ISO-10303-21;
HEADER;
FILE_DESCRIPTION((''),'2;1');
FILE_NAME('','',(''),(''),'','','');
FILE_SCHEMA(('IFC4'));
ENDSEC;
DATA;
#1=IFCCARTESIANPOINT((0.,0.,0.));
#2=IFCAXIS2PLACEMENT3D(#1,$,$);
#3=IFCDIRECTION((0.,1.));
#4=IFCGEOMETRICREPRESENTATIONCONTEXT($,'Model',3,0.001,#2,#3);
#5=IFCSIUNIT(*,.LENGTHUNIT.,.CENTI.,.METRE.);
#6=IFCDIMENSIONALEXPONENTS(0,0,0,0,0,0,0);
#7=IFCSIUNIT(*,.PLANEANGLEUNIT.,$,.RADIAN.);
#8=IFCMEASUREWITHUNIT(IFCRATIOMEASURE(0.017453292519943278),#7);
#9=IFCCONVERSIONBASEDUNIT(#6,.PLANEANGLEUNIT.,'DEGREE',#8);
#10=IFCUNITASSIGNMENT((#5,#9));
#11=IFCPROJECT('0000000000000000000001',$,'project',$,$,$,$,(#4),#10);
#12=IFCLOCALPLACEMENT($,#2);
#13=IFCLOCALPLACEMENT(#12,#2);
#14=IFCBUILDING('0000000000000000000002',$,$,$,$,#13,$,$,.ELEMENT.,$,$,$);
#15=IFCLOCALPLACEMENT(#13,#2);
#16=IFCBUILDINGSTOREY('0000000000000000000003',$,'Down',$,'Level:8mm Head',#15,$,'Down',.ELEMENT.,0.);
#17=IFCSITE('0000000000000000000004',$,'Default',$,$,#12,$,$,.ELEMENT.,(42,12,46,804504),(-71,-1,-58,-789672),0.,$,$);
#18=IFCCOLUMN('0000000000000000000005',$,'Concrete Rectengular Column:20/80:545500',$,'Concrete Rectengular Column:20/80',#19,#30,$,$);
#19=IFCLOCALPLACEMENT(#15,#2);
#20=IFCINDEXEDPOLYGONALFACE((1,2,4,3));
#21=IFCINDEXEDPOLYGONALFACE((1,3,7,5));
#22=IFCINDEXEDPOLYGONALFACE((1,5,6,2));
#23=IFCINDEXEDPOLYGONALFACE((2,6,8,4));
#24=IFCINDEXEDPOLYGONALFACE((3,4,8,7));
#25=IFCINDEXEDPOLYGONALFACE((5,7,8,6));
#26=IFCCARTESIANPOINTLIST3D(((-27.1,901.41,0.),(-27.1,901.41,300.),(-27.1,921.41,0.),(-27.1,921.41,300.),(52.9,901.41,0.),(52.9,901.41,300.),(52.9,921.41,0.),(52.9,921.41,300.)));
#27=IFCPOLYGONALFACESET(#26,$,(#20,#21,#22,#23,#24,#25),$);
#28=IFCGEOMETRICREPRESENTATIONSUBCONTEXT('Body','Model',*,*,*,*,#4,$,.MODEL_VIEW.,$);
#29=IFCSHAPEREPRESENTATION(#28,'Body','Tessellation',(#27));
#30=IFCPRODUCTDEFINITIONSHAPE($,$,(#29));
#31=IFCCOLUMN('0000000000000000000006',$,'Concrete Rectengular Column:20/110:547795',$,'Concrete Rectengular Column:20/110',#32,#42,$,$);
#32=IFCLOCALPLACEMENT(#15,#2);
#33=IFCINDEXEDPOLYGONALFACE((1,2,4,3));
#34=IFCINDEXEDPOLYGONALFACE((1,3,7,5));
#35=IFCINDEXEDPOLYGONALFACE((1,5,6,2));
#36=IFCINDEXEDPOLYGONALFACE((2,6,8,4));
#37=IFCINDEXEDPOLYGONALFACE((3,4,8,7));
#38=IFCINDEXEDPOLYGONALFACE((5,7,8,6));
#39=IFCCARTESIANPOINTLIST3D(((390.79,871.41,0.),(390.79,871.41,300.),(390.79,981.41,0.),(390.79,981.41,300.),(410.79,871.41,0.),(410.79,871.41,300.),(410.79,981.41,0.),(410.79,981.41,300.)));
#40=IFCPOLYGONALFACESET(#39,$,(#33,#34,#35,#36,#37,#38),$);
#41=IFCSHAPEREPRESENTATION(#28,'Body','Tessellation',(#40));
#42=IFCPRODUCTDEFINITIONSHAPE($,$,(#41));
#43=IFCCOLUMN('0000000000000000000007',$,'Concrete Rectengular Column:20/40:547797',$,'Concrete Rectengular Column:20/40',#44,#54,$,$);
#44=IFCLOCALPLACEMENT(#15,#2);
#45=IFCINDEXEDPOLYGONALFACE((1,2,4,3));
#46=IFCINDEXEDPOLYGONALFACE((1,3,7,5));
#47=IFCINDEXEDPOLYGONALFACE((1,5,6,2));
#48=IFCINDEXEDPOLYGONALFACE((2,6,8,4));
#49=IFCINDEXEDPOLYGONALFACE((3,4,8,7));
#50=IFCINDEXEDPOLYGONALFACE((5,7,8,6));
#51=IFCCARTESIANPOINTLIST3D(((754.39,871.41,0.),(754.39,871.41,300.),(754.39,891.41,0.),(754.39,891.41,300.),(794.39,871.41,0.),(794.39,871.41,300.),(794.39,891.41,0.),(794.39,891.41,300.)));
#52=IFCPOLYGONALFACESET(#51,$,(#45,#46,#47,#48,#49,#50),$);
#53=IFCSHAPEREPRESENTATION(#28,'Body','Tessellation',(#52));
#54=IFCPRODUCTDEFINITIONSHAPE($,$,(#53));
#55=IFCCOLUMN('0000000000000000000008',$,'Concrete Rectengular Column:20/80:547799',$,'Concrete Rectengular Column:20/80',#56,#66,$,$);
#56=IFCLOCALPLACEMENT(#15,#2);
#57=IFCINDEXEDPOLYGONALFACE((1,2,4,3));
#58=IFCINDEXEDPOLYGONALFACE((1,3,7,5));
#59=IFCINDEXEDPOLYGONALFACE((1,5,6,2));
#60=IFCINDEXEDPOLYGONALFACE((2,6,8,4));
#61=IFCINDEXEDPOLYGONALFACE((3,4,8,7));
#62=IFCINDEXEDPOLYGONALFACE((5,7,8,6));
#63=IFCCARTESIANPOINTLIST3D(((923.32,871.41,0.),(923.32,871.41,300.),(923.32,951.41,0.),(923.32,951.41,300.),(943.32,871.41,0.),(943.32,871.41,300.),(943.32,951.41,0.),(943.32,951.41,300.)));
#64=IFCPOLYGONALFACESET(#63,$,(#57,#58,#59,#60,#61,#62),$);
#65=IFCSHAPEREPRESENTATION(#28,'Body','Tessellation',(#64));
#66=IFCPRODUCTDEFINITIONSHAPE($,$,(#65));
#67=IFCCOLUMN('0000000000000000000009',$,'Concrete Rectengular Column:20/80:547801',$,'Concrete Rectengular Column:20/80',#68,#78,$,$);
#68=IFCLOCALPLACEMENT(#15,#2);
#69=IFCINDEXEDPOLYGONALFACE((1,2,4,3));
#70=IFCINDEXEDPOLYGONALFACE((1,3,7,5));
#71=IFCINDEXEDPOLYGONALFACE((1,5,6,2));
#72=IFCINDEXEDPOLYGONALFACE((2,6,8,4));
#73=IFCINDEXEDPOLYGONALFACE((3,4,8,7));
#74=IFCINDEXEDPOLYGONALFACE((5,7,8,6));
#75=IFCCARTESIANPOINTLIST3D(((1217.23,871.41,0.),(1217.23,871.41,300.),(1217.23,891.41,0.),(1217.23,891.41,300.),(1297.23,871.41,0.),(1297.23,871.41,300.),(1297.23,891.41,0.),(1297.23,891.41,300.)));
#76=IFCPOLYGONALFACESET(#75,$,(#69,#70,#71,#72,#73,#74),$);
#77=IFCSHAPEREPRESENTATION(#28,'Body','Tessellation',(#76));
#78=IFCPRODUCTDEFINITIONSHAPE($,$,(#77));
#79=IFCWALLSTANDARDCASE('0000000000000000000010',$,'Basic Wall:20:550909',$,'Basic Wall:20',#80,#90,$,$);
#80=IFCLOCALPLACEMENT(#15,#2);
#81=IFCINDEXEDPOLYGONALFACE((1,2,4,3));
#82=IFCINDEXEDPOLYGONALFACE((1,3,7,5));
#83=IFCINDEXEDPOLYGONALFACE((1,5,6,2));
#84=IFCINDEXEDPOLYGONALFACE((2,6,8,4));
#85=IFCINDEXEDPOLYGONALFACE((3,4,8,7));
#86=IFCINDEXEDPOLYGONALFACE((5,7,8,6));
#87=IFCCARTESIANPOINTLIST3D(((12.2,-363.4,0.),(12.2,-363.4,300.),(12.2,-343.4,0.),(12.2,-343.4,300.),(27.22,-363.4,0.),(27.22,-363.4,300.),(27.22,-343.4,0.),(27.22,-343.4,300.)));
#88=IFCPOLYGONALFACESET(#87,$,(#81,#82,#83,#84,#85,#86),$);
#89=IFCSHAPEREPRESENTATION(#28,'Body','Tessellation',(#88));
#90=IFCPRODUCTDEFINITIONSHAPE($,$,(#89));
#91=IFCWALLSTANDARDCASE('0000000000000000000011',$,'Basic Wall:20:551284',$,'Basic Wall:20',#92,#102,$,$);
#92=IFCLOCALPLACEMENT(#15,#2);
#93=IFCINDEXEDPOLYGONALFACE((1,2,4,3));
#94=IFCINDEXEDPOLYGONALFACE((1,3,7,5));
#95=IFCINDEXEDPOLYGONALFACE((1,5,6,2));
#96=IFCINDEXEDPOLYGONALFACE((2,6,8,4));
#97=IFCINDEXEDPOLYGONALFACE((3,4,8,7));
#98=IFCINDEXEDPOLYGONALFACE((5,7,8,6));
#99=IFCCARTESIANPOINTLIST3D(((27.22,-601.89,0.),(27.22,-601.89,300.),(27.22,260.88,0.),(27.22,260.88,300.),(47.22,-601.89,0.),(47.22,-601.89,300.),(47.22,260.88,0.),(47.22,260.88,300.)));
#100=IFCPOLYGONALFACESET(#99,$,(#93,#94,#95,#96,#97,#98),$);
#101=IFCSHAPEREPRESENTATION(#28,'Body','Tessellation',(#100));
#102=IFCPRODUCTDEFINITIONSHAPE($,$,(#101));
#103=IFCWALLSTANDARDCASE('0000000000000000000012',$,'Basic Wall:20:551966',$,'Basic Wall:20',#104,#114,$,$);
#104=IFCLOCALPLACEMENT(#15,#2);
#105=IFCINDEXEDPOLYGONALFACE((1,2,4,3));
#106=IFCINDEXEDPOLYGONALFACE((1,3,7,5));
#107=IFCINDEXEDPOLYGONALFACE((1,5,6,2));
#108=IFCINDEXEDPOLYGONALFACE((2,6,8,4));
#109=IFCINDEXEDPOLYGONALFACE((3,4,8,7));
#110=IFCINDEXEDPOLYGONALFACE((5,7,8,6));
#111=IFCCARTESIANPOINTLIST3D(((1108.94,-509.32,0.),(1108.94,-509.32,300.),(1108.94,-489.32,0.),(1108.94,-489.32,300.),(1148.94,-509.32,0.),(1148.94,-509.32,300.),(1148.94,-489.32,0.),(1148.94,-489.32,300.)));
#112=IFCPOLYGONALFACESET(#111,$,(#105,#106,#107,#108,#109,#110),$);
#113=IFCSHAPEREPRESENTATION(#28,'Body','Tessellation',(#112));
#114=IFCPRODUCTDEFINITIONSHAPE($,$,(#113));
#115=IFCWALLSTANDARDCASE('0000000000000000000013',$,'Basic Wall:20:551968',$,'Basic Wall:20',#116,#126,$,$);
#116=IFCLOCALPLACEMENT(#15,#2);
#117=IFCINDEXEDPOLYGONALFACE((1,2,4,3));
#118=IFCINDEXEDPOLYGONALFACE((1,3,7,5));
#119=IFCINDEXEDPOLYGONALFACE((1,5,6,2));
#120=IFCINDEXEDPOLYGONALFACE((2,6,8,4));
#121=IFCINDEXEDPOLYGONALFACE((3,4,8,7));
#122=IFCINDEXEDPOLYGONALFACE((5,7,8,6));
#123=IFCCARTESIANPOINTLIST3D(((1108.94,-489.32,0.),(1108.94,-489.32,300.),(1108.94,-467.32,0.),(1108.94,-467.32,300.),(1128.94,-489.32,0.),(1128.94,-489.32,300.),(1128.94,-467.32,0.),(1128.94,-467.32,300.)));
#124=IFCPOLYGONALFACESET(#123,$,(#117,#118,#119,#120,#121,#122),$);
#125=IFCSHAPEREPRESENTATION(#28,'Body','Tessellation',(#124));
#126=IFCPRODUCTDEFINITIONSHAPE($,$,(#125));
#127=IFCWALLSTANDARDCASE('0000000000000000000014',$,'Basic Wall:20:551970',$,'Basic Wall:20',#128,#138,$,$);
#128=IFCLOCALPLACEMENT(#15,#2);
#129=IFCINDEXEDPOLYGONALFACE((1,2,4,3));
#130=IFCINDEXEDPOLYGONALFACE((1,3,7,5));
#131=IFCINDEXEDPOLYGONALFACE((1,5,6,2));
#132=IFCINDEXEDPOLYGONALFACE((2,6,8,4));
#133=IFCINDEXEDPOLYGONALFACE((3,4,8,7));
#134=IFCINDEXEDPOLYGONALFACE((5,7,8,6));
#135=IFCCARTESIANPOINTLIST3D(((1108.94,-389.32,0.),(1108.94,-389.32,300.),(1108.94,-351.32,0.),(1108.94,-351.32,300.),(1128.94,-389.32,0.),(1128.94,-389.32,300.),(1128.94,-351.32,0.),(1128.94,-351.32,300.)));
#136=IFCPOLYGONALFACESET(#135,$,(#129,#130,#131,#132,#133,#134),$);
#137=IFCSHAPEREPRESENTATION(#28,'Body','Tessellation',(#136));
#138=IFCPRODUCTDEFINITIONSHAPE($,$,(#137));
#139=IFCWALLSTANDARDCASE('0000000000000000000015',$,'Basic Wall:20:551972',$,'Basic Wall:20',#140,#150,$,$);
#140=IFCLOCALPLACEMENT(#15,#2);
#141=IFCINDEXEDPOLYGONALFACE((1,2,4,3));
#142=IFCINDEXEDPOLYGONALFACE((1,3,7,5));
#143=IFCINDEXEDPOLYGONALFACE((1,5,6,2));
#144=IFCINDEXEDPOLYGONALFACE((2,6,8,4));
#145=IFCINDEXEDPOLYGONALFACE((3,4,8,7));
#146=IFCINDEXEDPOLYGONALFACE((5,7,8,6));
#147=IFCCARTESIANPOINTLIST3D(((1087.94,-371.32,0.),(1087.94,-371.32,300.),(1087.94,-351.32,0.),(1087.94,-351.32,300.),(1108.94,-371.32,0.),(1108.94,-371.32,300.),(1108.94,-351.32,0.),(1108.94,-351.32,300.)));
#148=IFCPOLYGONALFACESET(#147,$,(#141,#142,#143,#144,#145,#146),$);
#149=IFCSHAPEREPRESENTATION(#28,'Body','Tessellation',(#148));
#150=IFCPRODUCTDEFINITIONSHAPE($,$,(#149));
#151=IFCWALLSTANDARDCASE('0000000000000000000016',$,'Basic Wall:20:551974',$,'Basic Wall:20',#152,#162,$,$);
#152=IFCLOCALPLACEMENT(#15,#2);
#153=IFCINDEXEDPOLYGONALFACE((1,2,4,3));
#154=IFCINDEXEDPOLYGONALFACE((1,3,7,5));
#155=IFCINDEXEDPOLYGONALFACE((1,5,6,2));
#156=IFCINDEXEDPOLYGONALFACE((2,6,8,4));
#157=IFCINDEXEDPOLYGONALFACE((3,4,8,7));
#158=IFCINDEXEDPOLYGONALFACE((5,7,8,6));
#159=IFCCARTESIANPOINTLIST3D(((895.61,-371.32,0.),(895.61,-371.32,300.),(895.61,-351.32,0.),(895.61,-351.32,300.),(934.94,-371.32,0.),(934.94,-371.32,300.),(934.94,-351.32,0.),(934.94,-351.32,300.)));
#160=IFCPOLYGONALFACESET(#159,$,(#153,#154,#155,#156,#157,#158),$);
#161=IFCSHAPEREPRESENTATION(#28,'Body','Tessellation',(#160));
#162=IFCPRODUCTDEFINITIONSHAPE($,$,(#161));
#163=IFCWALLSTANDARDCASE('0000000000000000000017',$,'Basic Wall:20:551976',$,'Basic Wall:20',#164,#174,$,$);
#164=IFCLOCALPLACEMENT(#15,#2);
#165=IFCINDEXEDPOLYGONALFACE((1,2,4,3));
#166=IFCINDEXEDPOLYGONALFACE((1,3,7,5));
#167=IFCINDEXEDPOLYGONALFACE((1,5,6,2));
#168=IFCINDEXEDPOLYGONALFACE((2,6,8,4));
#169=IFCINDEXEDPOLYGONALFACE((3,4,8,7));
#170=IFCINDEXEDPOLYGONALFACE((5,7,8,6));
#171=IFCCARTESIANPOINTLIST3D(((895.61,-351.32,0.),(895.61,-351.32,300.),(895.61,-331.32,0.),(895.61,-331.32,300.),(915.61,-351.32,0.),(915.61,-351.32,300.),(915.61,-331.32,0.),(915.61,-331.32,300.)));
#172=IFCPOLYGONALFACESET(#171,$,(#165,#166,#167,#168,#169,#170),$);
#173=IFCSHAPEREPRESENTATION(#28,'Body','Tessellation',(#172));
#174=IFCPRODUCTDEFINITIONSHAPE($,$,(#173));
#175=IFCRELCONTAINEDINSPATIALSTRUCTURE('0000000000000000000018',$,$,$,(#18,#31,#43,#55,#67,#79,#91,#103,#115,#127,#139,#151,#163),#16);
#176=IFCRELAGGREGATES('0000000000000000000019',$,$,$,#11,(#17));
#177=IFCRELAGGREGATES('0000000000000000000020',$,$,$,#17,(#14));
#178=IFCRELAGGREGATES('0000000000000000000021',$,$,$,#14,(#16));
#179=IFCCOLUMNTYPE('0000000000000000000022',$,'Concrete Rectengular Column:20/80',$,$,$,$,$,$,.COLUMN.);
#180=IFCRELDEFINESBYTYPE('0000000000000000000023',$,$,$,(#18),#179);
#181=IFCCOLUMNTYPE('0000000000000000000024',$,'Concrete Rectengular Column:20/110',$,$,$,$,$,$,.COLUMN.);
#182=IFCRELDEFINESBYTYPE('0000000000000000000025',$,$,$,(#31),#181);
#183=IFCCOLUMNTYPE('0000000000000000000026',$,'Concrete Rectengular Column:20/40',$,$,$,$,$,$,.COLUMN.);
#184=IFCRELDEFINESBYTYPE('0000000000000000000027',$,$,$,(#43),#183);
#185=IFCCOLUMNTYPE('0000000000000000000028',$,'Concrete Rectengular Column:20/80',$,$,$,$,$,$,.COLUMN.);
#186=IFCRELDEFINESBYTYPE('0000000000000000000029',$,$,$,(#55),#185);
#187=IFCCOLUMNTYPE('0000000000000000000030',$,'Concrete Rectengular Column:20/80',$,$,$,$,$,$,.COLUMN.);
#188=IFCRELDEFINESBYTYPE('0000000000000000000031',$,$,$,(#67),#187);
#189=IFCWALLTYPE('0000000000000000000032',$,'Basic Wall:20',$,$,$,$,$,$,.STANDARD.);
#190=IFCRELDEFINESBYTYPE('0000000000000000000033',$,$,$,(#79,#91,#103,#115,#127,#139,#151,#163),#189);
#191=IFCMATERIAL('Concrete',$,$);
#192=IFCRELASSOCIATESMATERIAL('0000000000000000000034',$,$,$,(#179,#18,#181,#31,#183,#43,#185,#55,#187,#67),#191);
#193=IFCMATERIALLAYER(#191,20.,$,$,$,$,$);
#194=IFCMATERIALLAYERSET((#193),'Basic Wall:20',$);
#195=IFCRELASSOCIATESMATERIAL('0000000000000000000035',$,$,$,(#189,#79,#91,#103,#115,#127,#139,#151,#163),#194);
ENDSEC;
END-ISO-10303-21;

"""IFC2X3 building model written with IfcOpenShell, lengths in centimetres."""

from ifc_helpers import new_model, entity, si_unit, converted_unit, direction, frame, frame_2d, origin, origin_2d_with_axis, place, context, subcontext, project, spatial, rectangle, extrude, source, transform, mapped, material, layer, layer_set, layer_usage, type_object, type_shapes, element, save


model = new_model("IFC2X3")

# Units and contexts
model_context = context("Model", 3, precision=0.001, world=origin(), true_north=direction((0.0, 1.0)))
body_context = subcontext(model_context, "Body", "Model", "MODEL_VIEW")
ifc_project = project(units=[si_unit("LENGTHUNIT", "METRE", prefix="CENTI"), converted_unit("PLANEANGLEUNIT", "DEGREE", entity("IfcRatioMeasure", 0.017453292519943278), si_unit("PLANEANGLEUNIT", "RADIAN"), dimensions=[0, 0, 0, 0, 0, 0, 0])], contexts=[model_context])

# Site, building, storey
site_placement = place(None, origin())
site = spatial("IfcSite", under=ifc_project, at=site_placement, Name="Default", CompositionType="ELEMENT", RefLatitude=(42, 12, 46, 804504), RefLongitude=(-71, -1, -58, -789672), RefElevation=0.0)
building_placement = place(site_placement, origin())
building = spatial("IfcBuilding", under=site, at=building_placement, CompositionType="ELEMENT")
storey_placement = place(building_placement, origin())
storey = spatial("IfcBuildingStorey", under=building, at=storey_placement, Name="Down", ObjectType="Level:8mm Head", LongName="Down", CompositionType="ELEMENT", Elevation=0.0)

# Columns
ifc_material = material(Name="Concrete")
column_type_1 = type_object("IfcColumnType", Name="Concrete Rectengular Column:20/80", PredefinedType="COLUMN", material=ifc_material)
shared_shape_1 = source(origin(), body_context, "Body", "SweptSolid", [
    extrude(rectangle(XDim=20.0, YDim=80.0, at=origin_2d_with_axis()), frame((12.9, 911.41, 0.0), z_axis=(0.0, 0.0, 1.0), x_axis=(0.0, -1.0, 0.0)), (0.0, 0.0, 1.0), 300.0),
])
type_shapes(column_type_1, [shared_shape_1])
column_1_placement = place(storey_placement, origin())
element("IfcColumn", 1, at=column_1_placement, inside=storey, type_object=column_type_1, material=ifc_material, Name="Concrete Rectengular Column:20/80:545500", ObjectType="Concrete Rectengular Column:20/80", context=body_context, shape_type="MappedRepresentation", body=[
    mapped(shared_shape_1, transform((0.0, 0.0, 0.0), scale=1.0)),
])
column_type_2 = type_object("IfcColumnType", Name="Concrete Rectengular Column:20/110", PredefinedType="COLUMN", material=ifc_material)
shared_shape_2 = source(origin(), body_context, "Body", "SweptSolid", [
    extrude(rectangle(XDim=110.0, YDim=20.0, at=frame_2d((0.0, 0.0), x_axis=(1.0, 0.0))), frame((400.79, 926.41, 0.0), z_axis=(0.0, 0.0, 1.0), x_axis=(0.0, -1.0, 0.0)), (0.0, 0.0, 1.0), 300.0),
])
type_shapes(column_type_2, [shared_shape_2])
column_2_placement = place(storey_placement, origin())
element("IfcColumn", 2, at=column_2_placement, inside=storey, type_object=column_type_2, material=ifc_material, Name="Concrete Rectengular Column:20/110:547795", ObjectType="Concrete Rectengular Column:20/110", context=body_context, shape_type="MappedRepresentation", body=[
    mapped(shared_shape_2, transform((0.0, 0.0, 0.0), scale=1.0)),
])
column_type_3 = type_object("IfcColumnType", Name="Concrete Rectengular Column:20/40", PredefinedType="COLUMN", material=ifc_material)
shared_shape_3 = source(origin(), body_context, "Body", "SweptSolid", [
    extrude(rectangle(XDim=20.0, YDim=40.0, at=origin_2d_with_axis()), frame((774.39, 881.41, 0.0), z_axis=(0.0, 0.0, 1.0), x_axis=(0.0, -1.0, 0.0)), (0.0, 0.0, 1.0), 300.0),
])
type_shapes(column_type_3, [shared_shape_3])
column_3_placement = place(storey_placement, origin())
element("IfcColumn", 3, at=column_3_placement, inside=storey, type_object=column_type_3, material=ifc_material, Name="Concrete Rectengular Column:20/40:547797", ObjectType="Concrete Rectengular Column:20/40", context=body_context, shape_type="MappedRepresentation", body=[
    mapped(shared_shape_3, transform((0.0, 0.0, 0.0), scale=1.0)),
])
column_type_4 = type_object("IfcColumnType", Name="Concrete Rectengular Column:20/80", PredefinedType="COLUMN", material=ifc_material)
shared_shape_4 = source(origin(), body_context, "Body", "SweptSolid", [
    extrude(rectangle(XDim=80.0, YDim=20.0, at=origin_2d_with_axis()), frame((933.32, 911.41, 0.0), z_axis=(0.0, 0.0, 1.0), x_axis=(0.0, -1.0, 0.0)), (0.0, 0.0, 1.0), 300.0),
])
type_shapes(column_type_4, [shared_shape_4])
column_4_placement = place(storey_placement, origin())
element("IfcColumn", 4, at=column_4_placement, inside=storey, type_object=column_type_4, material=ifc_material, Name="Concrete Rectengular Column:20/80:547799", ObjectType="Concrete Rectengular Column:20/80", context=body_context, shape_type="MappedRepresentation", body=[
    mapped(shared_shape_4, transform((0.0, 0.0, 0.0), scale=1.0)),
])
column_type_5 = type_object("IfcColumnType", Name="Concrete Rectengular Column:20/80", PredefinedType="COLUMN", material=ifc_material)
shared_shape_5 = source(origin(), body_context, "Body", "SweptSolid", [
    extrude(rectangle(XDim=20.0, YDim=80.0, at=origin_2d_with_axis()), frame((1257.23, 881.41, 0.0), z_axis=(0.0, 0.0, 1.0), x_axis=(0.0, -1.0, 0.0)), (0.0, 0.0, 1.0), 300.0),
])
type_shapes(column_type_5, [shared_shape_5])
column_5_placement = place(storey_placement, origin())
element("IfcColumn", 5, at=column_5_placement, inside=storey, type_object=column_type_5, material=ifc_material, Name="Concrete Rectengular Column:20/80:547801", ObjectType="Concrete Rectengular Column:20/80", context=body_context, shape_type="MappedRepresentation", body=[
    mapped(shared_shape_5, transform((0.0, 0.0, 0.0), scale=1.0)),
])

# Walls
ifc_layer_1 = layer(ifc_material, 20.0)
ifc_layer_set_1 = layer_set([ifc_layer_1], Name="Basic Wall:20")
ifc_layer_usage_1 = layer_usage(ifc_layer_set_1, "AXIS2", "POSITIVE", -10.0)
wall_type_1 = type_object("IfcWallType", Name="Basic Wall:20", PredefinedType="STANDARD", material=ifc_layer_set_1)
wall_1_placement = place(storey_placement, frame((27.22, -353.4, 0.0), z_axis=(0.0, 0.0, 1.0), x_axis=(-1.0, 0.0, 0.0)))
element("IfcWallStandardCase", 6, at=wall_1_placement, inside=storey, type_object=wall_type_1, material=ifc_layer_usage_1, Name="Basic Wall:20:550909", ObjectType="Basic Wall:20", context=body_context, shape_type="SweptSolid", body=[
    extrude(rectangle(XDim=15.02, YDim=20.0, at=frame_2d((7.51, 0.0), x_axis=(-1.0, 0.0))), origin(), (0.0, 0.0, 1.0), 300.0),
])
ifc_layer_usage_2 = layer_usage(ifc_layer_set_1, "AXIS2", "NEGATIVE", 10.0)
wall_2_placement = place(storey_placement, frame((37.22, -601.89, 0.0), z_axis=(0.0, 0.0, 1.0), x_axis=(0.0, 1.0, 0.0)))
element("IfcWallStandardCase", 7, at=wall_2_placement, inside=storey, type_object=wall_type_1, material=ifc_layer_usage_2, Name="Basic Wall:20:551284", ObjectType="Basic Wall:20", context=body_context, shape_type="SweptSolid", body=[
    extrude(rectangle(XDim=862.77, YDim=20.0, at=frame_2d((431.39, 0.0), x_axis=(-1.0, 0.0))), origin(), (0.0, 0.0, 1.0), 300.0),
])
ifc_layer_usage_3 = layer_usage(ifc_layer_set_1, "AXIS2", "POSITIVE", -10.0)
wall_3_placement = place(storey_placement, frame((1148.94, -499.32, 0.0), z_axis=(0.0, 0.0, 1.0), x_axis=(-1.0, 0.0, 0.0)))
element("IfcWallStandardCase", 8, at=wall_3_placement, inside=storey, type_object=wall_type_1, material=ifc_layer_usage_3, Name="Basic Wall:20:551966", ObjectType="Basic Wall:20", context=body_context, shape_type="SweptSolid", body=[
    extrude(rectangle(XDim=40.0, YDim=20.0, at=frame_2d((20.0, 0.0), x_axis=(-1.0, 0.0))), origin(), (0.0, 0.0, 1.0), 300.0),
])
ifc_layer_usage_4 = layer_usage(ifc_layer_set_1, "AXIS2", "NEGATIVE", 10.0)
wall_4_placement = place(storey_placement, frame((1118.94, -489.32, 0.0), z_axis=(0.0, 0.0, 1.0), x_axis=(0.0, 1.0, 0.0)))
element("IfcWallStandardCase", 9, at=wall_4_placement, inside=storey, type_object=wall_type_1, material=ifc_layer_usage_4, Name="Basic Wall:20:551968", ObjectType="Basic Wall:20", context=body_context, shape_type="SweptSolid", body=[
    extrude(rectangle(XDim=22.0, YDim=20.0, at=frame_2d((11.0, 0.0), x_axis=(-1.0, 0.0))), origin(), (0.0, 0.0, 1.0), 300.0),
])
ifc_layer_usage_5 = layer_usage(ifc_layer_set_1, "AXIS2", "NEGATIVE", 10.0)
wall_5_placement = place(storey_placement, frame((1118.94, -389.32, 0.0), z_axis=(0.0, 0.0, 1.0), x_axis=(0.0, 1.0, 0.0)))
element("IfcWallStandardCase", 10, at=wall_5_placement, inside=storey, type_object=wall_type_1, material=ifc_layer_usage_5, Name="Basic Wall:20:551970", ObjectType="Basic Wall:20", context=body_context, shape_type="SweptSolid", body=[
    extrude(rectangle(XDim=38.0, YDim=20.0, at=frame_2d((19.0, 0.0), x_axis=(-1.0, 0.0))), origin(), (0.0, 0.0, 1.0), 300.0),
])
ifc_layer_usage_6 = layer_usage(ifc_layer_set_1, "AXIS2", "POSITIVE", -10.0)
wall_6_placement = place(storey_placement, frame((1108.94, -361.32, 0.0), z_axis=(0.0, 0.0, 1.0), x_axis=(-1.0, 0.0, 0.0)))
element("IfcWallStandardCase", 11, at=wall_6_placement, inside=storey, type_object=wall_type_1, material=ifc_layer_usage_6, Name="Basic Wall:20:551972", ObjectType="Basic Wall:20", context=body_context, shape_type="SweptSolid", body=[
    extrude(rectangle(XDim=21.0, YDim=20.0, at=frame_2d((10.5, 0.0), x_axis=(-1.0, 0.0))), origin(), (0.0, 0.0, 1.0), 300.0),
])
ifc_layer_usage_7 = layer_usage(ifc_layer_set_1, "AXIS2", "POSITIVE", -10.0)
wall_7_placement = place(storey_placement, frame((934.94, -361.32, 0.0), z_axis=(0.0, 0.0, 1.0), x_axis=(-1.0, 0.0, 0.0)))
element("IfcWallStandardCase", 12, at=wall_7_placement, inside=storey, type_object=wall_type_1, material=ifc_layer_usage_7, Name="Basic Wall:20:551974", ObjectType="Basic Wall:20", context=body_context, shape_type="SweptSolid", body=[
    extrude(rectangle(XDim=39.33, YDim=20.0, at=frame_2d((19.67, 0.0), x_axis=(-1.0, 0.0))), origin(), (0.0, 0.0, 1.0), 300.0),
])
ifc_layer_usage_8 = layer_usage(ifc_layer_set_1, "AXIS2", "NEGATIVE", 10.0)
wall_8_placement = place(storey_placement, frame((905.61, -351.32, 0.0), z_axis=(0.0, 0.0, 1.0), x_axis=(0.0, 1.0, 0.0)))
element("IfcWallStandardCase", 13, at=wall_8_placement, inside=storey, type_object=wall_type_1, material=ifc_layer_usage_8, Name="Basic Wall:20:551976", ObjectType="Basic Wall:20", context=body_context, shape_type="SweptSolid", body=[
    extrude(rectangle(XDim=20.0, YDim=20.0, at=frame_2d((10.0, 0.0), x_axis=(-1.0, 0.0))), origin(), (0.0, 0.0, 1.0), 300.0),
])

save(model, "model.ifc")
